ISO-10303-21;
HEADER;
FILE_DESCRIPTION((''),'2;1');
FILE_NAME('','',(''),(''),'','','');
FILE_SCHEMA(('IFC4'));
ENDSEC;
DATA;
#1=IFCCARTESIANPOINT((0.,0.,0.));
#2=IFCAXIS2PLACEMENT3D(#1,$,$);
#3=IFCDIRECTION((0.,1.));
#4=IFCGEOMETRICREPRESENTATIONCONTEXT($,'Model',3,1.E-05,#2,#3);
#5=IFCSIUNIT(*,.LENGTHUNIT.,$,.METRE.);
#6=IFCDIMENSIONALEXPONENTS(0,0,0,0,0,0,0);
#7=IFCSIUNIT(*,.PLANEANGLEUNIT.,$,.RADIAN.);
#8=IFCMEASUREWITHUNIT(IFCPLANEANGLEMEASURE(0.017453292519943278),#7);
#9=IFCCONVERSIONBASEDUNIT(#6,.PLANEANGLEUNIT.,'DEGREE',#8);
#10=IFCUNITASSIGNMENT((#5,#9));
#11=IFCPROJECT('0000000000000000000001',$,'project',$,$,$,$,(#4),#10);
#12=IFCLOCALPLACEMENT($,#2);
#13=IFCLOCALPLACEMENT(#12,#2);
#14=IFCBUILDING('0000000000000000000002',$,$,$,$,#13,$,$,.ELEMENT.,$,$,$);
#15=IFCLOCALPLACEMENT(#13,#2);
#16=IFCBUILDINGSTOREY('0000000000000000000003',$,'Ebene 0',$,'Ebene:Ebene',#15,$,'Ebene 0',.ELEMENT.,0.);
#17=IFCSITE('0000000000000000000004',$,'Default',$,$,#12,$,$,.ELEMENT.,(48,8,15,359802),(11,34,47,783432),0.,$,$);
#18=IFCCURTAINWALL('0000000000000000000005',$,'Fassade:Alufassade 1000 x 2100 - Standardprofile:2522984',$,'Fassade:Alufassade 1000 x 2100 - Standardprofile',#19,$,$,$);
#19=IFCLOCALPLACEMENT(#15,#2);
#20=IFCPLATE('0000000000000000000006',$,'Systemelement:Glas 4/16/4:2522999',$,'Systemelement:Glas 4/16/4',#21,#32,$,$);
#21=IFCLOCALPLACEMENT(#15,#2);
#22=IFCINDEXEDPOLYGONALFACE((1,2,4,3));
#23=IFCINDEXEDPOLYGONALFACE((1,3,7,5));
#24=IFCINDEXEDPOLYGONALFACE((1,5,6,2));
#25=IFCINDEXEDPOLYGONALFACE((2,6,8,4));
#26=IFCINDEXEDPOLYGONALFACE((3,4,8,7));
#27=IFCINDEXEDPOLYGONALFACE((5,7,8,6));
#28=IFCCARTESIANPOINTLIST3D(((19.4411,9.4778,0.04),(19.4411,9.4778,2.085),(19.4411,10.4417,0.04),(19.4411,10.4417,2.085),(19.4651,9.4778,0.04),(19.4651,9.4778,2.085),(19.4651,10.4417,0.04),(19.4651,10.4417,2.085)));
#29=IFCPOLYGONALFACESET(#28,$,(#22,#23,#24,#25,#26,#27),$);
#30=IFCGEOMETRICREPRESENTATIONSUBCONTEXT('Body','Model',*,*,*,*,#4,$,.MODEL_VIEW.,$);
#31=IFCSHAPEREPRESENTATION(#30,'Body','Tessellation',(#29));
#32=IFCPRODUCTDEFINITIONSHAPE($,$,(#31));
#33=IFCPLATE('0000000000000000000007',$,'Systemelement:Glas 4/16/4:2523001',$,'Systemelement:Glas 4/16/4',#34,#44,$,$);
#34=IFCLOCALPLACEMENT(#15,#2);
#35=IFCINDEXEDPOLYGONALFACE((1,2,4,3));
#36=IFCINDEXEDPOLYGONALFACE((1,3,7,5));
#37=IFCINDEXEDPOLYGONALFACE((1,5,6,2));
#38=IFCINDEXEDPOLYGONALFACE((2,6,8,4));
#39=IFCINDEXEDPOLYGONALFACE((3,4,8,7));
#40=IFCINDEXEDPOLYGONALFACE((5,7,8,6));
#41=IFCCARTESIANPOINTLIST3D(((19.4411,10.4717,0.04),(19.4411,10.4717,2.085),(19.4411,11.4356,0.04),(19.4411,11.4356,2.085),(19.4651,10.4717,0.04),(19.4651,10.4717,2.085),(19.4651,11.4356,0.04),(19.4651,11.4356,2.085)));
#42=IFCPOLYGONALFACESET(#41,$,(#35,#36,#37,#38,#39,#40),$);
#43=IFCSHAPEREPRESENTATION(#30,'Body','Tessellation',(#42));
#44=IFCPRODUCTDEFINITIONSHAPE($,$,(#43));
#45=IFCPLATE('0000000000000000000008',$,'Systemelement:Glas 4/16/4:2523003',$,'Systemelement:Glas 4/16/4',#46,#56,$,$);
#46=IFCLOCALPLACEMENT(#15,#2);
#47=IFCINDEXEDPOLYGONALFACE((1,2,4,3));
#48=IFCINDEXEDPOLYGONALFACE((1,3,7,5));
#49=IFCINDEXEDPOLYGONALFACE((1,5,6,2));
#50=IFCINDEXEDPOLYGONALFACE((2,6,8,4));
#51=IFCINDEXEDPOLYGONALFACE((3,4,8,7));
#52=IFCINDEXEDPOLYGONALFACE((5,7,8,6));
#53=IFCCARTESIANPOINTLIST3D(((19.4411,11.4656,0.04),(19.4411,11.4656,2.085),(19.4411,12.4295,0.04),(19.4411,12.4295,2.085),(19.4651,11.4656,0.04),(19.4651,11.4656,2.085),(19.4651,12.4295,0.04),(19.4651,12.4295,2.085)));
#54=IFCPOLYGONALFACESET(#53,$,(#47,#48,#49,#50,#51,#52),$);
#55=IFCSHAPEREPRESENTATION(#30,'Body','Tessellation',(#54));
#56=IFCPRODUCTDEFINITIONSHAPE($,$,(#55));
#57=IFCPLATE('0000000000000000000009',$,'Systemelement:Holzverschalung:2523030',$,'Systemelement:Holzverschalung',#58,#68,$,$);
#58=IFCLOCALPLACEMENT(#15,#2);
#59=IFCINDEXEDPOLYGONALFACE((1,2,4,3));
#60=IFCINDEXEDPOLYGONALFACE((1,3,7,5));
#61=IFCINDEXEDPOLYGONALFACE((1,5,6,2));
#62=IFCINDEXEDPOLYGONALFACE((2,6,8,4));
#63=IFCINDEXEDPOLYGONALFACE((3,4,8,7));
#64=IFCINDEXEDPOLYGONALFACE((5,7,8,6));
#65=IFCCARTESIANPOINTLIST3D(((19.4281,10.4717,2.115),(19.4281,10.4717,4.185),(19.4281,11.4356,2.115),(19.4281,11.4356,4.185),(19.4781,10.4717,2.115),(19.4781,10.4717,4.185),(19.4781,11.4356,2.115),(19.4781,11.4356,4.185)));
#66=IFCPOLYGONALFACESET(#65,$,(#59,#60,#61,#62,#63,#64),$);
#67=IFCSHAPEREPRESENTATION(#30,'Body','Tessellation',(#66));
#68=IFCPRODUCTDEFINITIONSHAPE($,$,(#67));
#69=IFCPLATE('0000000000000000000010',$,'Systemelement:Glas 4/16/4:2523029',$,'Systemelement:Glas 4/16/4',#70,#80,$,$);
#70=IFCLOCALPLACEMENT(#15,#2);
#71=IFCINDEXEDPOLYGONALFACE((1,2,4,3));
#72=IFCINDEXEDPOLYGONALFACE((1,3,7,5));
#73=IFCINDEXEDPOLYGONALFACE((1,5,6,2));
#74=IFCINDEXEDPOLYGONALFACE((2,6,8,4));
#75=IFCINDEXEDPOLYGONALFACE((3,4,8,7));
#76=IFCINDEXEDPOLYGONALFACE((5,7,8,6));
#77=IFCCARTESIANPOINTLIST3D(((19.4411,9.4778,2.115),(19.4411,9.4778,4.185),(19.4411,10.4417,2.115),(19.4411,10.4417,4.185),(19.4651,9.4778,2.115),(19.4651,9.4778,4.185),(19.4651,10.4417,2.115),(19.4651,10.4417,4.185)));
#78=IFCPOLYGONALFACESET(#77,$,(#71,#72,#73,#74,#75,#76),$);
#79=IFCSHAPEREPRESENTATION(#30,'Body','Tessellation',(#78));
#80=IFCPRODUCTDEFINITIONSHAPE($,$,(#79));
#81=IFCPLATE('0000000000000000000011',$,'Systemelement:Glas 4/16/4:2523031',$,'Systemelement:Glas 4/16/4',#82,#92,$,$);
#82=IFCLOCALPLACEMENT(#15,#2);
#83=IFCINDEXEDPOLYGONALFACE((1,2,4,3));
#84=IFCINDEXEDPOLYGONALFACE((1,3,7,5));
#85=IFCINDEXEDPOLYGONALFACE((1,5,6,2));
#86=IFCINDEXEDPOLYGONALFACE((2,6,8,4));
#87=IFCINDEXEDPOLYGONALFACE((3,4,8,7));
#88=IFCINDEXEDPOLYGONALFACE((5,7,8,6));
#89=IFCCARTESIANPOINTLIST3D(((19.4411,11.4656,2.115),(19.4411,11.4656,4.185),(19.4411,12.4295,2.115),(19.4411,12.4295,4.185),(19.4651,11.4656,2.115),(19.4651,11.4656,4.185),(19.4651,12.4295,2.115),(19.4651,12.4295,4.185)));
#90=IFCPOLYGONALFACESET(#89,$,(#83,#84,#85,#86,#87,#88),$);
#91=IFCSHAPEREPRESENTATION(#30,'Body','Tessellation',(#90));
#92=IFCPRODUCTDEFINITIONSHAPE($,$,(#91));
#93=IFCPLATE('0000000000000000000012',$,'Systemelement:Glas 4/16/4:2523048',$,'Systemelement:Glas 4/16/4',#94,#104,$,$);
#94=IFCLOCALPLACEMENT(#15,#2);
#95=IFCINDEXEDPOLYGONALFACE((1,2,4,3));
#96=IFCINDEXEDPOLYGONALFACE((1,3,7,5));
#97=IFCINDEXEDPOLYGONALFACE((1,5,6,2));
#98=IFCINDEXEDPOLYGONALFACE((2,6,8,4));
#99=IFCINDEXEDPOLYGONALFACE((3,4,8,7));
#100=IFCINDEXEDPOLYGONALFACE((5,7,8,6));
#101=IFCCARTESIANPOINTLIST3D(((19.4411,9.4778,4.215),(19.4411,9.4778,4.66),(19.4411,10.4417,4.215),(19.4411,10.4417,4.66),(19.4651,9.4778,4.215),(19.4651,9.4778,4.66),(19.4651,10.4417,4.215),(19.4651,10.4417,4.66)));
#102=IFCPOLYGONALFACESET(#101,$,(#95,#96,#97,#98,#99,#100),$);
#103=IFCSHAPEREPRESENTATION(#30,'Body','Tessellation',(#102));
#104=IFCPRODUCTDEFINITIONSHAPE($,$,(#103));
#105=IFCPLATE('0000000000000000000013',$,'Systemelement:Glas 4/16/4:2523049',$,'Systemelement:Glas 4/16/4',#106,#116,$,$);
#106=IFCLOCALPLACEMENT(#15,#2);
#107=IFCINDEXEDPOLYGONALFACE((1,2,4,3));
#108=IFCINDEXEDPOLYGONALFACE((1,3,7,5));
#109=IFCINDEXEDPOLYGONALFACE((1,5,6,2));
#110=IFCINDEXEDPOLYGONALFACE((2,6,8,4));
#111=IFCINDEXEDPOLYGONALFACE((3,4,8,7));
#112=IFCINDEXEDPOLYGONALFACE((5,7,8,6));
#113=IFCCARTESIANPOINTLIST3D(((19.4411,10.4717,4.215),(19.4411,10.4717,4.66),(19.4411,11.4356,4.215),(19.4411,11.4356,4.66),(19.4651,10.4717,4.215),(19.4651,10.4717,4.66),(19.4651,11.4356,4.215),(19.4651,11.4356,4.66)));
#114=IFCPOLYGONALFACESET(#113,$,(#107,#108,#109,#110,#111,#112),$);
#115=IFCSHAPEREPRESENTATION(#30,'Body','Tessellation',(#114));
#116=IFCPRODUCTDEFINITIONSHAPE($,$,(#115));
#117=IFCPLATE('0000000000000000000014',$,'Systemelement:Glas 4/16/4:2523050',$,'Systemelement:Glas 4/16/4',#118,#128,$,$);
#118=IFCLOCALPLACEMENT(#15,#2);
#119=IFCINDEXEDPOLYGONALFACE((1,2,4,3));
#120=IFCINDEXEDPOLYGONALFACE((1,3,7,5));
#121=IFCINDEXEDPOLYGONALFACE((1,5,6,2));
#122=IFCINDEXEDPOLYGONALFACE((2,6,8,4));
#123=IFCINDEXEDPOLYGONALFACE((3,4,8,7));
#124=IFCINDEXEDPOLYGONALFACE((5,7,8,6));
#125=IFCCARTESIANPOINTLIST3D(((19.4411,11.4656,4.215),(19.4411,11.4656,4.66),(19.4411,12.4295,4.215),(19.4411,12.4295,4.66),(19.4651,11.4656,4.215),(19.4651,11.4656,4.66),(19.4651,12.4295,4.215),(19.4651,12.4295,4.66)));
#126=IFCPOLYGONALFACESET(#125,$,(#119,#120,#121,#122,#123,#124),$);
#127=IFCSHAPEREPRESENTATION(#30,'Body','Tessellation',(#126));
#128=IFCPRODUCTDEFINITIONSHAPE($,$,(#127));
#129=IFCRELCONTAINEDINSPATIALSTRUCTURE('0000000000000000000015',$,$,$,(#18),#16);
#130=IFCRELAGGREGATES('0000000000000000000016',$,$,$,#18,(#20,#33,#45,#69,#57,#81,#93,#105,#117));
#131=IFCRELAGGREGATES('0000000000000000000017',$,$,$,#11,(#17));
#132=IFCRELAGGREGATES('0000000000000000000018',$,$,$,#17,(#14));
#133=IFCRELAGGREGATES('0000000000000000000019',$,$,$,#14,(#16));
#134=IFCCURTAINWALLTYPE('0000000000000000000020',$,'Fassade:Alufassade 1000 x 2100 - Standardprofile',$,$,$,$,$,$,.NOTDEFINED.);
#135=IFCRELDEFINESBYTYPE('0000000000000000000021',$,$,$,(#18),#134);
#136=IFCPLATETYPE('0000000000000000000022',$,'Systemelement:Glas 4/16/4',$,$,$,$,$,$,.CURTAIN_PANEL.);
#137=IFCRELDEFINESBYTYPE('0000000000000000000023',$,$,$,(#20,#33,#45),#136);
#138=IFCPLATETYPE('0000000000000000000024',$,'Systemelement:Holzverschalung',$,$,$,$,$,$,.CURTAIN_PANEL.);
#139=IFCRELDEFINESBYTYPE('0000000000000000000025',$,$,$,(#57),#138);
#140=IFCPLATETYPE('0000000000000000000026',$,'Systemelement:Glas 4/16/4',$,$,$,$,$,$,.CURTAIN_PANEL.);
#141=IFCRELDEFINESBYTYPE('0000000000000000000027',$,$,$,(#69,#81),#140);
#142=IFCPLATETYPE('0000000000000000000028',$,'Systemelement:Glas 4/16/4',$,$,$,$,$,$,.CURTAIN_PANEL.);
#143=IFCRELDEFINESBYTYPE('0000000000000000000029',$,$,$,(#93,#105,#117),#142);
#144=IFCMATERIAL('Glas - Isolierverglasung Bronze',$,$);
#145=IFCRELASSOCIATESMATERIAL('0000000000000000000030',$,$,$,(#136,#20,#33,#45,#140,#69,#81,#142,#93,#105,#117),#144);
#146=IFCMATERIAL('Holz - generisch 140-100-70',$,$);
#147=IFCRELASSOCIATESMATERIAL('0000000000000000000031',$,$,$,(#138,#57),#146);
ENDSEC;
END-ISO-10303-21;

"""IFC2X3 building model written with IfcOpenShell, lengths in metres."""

from ifc_helpers import new_model, entity, si_unit, converted_unit, direction, frame, origin, origin_2d_with_axis, place, context, subcontext, project, spatial, rectangle, extrude, source, transform, mapped, material, type_object, type_shapes, element, aggregate, save


model = new_model("IFC2X3")

# Units and contexts
model_context = context("Model", 3, precision=1e-05, world=origin(), true_north=direction((0.0, 1.0)))
body_context = subcontext(model_context, "Body", "Model", "MODEL_VIEW")
ifc_project = project(units=[si_unit("LENGTHUNIT", "METRE"), converted_unit("PLANEANGLEUNIT", "DEGREE", entity("IfcPlaneAngleMeasure", 0.017453292519943278), si_unit("PLANEANGLEUNIT", "RADIAN"), dimensions=[0, 0, 0, 0, 0, 0, 0])], contexts=[model_context])

# Site, building, storey
site_placement = place(None, origin())
site = spatial("IfcSite", under=ifc_project, at=site_placement, Name="Default", CompositionType="ELEMENT", RefLatitude=(48, 8, 15, 359802), RefLongitude=(11, 34, 47, 783432), RefElevation=0.0)
building_placement = place(site_placement, origin())
building = spatial("IfcBuilding", under=site, at=building_placement, CompositionType="ELEMENT")
storey_placement = place(building_placement, origin())
storey = spatial("IfcBuildingStorey", under=building, at=storey_placement, Name="Ebene 0", ObjectType="Ebene:Ebene", LongName="Ebene 0", CompositionType="ELEMENT", Elevation=0.0)

# Curtain wall, plates
curtain_wall_type = type_object("IfcCurtainWallType", Name="Fassade:Alufassade 1000 x 2100 - Standardprofile", PredefinedType="NOTDEFINED")
curtain_wall_placement = place(storey_placement, origin())
curtain_wall = element("IfcCurtainWall", 1, at=curtain_wall_placement, inside=storey, type_object=curtain_wall_type, Name="Fassade:Alufassade 1000 x 2100 - Standardprofile:2522984", ObjectType="Fassade:Alufassade 1000 x 2100 - Standardprofile")
ifc_material_1 = material(Name="Glas - Isolierverglasung Bronze")
plate_type_1 = type_object("IfcPlateType", Name="Systemelement:Glas 4/16/4", PredefinedType="CURTAIN_PANEL", material=ifc_material_1)
shared_shape_1 = source(origin(), body_context, "Body", "SweptSolid", [
    extrude(rectangle(XDim=0.024, YDim=0.9639, at=origin_2d_with_axis()), frame((0.0, 0.0, 0.0), z_axis=(0.0, 0.0, 1.0), x_axis=(0.0, 1.0, 0.0)), (0.0, 0.0, 1.0), 2.045),
])
type_shapes(plate_type_1, [shared_shape_1])
plate_1_placement = place(curtain_wall_placement, frame((19.4531, 9.9598, 0.04), z_axis=(0.0, 0.0, 1.0), x_axis=(0.0, 1.0, 0.0)))
plate_1 = element("IfcPlate", 2, at=plate_1_placement, type_object=plate_type_1, material=ifc_material_1, Name="Systemelement:Glas 4/16/4:2522999", ObjectType="Systemelement:Glas 4/16/4", context=body_context, shape_type="MappedRepresentation", body=[
    mapped(shared_shape_1, transform((0.0, 0.0, 0.0), scale=1.0)),
])
plate_2_placement = place(curtain_wall_placement, frame((19.4531, 10.9537, 0.04), z_axis=(0.0, 0.0, 1.0), x_axis=(0.0, 1.0, 0.0)))
plate_2 = element("IfcPlate", 3, at=plate_2_placement, type_object=plate_type_1, material=ifc_material_1, Name="Systemelement:Glas 4/16/4:2523001", ObjectType="Systemelement:Glas 4/16/4", context=body_context, shape_type="MappedRepresentation", body=[
    mapped(shared_shape_1, transform((0.0, 0.0, 0.0), scale=1.0)),
])
plate_3_placement = place(curtain_wall_placement, frame((19.4531, 11.9476, 0.04), z_axis=(0.0, 0.0, 1.0), x_axis=(0.0, 1.0, 0.0)))
plate_3 = element("IfcPlate", 4, at=plate_3_placement, type_object=plate_type_1, material=ifc_material_1, Name="Systemelement:Glas 4/16/4:2523003", ObjectType="Systemelement:Glas 4/16/4", context=body_context, shape_type="MappedRepresentation", body=[
    mapped(shared_shape_1, transform((0.0, 0.0, 0.0), scale=1.0)),
])
ifc_material_2 = material(Name="Holz - generisch 140-100-70")
plate_type_2 = type_object("IfcPlateType", Name="Systemelement:Holzverschalung", PredefinedType="CURTAIN_PANEL", material=ifc_material_2)
shared_shape_2 = source(origin(), body_context, "Body", "SweptSolid", [
    extrude(rectangle(XDim=0.05, YDim=0.9639, at=origin_2d_with_axis()), frame((0.0, 0.0, 0.0), z_axis=(0.0, 0.0, 1.0), x_axis=(0.0, 1.0, 0.0)), (0.0, 0.0, 1.0), 2.07),
])
type_shapes(plate_type_2, [shared_shape_2])
plate_4_placement = place(curtain_wall_placement, frame((19.4531, 10.9537, 2.115), z_axis=(0.0, 0.0, 1.0), x_axis=(0.0, 1.0, 0.0)))
plate_4 = element("IfcPlate", 5, at=plate_4_placement, type_object=plate_type_2, material=ifc_material_2, Name="Systemelement:Holzverschalung:2523030", ObjectType="Systemelement:Holzverschalung", context=body_context, shape_type="MappedRepresentation", body=[
    mapped(shared_shape_2, transform((0.0, 0.0, 0.0), scale=1.0)),
])
plate_type_3 = type_object("IfcPlateType", Name="Systemelement:Glas 4/16/4", PredefinedType="CURTAIN_PANEL", material=ifc_material_1)
shared_shape_3 = source(origin(), body_context, "Body", "SweptSolid", [
    extrude(rectangle(XDim=0.024, YDim=0.9639, at=origin_2d_with_axis()), frame((0.0, 0.0, 0.0), z_axis=(0.0, 0.0, 1.0), x_axis=(0.0, 1.0, 0.0)), (0.0, 0.0, 1.0), 2.07),
])
type_shapes(plate_type_3, [shared_shape_3])
plate_5_placement = place(curtain_wall_placement, frame((19.4531, 9.9598, 2.115), z_axis=(0.0, 0.0, 1.0), x_axis=(0.0, 1.0, 0.0)))
plate_5 = element("IfcPlate", 6, at=plate_5_placement, type_object=plate_type_3, material=ifc_material_1, Name="Systemelement:Glas 4/16/4:2523029", ObjectType="Systemelement:Glas 4/16/4", context=body_context, shape_type="MappedRepresentation", body=[
    mapped(shared_shape_3, transform((0.0, 0.0, 0.0), scale=1.0)),
])
plate_6_placement = place(curtain_wall_placement, frame((19.4531, 11.9476, 2.115), z_axis=(0.0, 0.0, 1.0), x_axis=(0.0, 1.0, 0.0)))
plate_6 = element("IfcPlate", 7, at=plate_6_placement, type_object=plate_type_3, material=ifc_material_1, Name="Systemelement:Glas 4/16/4:2523031", ObjectType="Systemelement:Glas 4/16/4", context=body_context, shape_type="MappedRepresentation", body=[
    mapped(shared_shape_3, transform((0.0, 0.0, 0.0), scale=1.0)),
])
plate_type_4 = type_object("IfcPlateType", Name="Systemelement:Glas 4/16/4", PredefinedType="CURTAIN_PANEL", material=ifc_material_1)
shared_shape_4 = source(origin(), body_context, "Body", "SweptSolid", [
    extrude(rectangle(XDim=0.024, YDim=0.9639, at=origin_2d_with_axis()), frame((0.0, 0.0, 0.0), z_axis=(0.0, 0.0, 1.0), x_axis=(0.0, 1.0, 0.0)), (0.0, 0.0, 1.0), 0.445),
])
type_shapes(plate_type_4, [shared_shape_4])
plate_7_placement = place(curtain_wall_placement, frame((19.4531, 9.9598, 4.215), z_axis=(0.0, 0.0, 1.0), x_axis=(0.0, 1.0, 0.0)))
plate_7 = element("IfcPlate", 8, at=plate_7_placement, type_object=plate_type_4, material=ifc_material_1, Name="Systemelement:Glas 4/16/4:2523048", ObjectType="Systemelement:Glas 4/16/4", context=body_context, shape_type="MappedRepresentation", body=[
    mapped(shared_shape_4, transform((0.0, 0.0, 0.0), scale=1.0)),
])
plate_8_placement = place(curtain_wall_placement, frame((19.4531, 10.9537, 4.215), z_axis=(0.0, 0.0, 1.0), x_axis=(0.0, 1.0, 0.0)))
plate_8 = element("IfcPlate", 9, at=plate_8_placement, type_object=plate_type_4, material=ifc_material_1, Name="Systemelement:Glas 4/16/4:2523049", ObjectType="Systemelement:Glas 4/16/4", context=body_context, shape_type="MappedRepresentation", body=[
    mapped(shared_shape_4, transform((0.0, 0.0, 0.0), scale=1.0)),
])
plate_9_placement = place(curtain_wall_placement, frame((19.4531, 11.9476, 4.215), z_axis=(0.0, 0.0, 1.0), x_axis=(0.0, 1.0, 0.0)))
plate_9 = element("IfcPlate", 10, at=plate_9_placement, type_object=plate_type_4, material=ifc_material_1, Name="Systemelement:Glas 4/16/4:2523050", ObjectType="Systemelement:Glas 4/16/4", context=body_context, shape_type="MappedRepresentation", body=[
    mapped(shared_shape_4, transform((0.0, 0.0, 0.0), scale=1.0)),
])
aggregate(curtain_wall, [plate_1, plate_2, plate_3, plate_5, plate_4, plate_6, plate_7, plate_8, plate_9])

save(model, "model.ifc")
